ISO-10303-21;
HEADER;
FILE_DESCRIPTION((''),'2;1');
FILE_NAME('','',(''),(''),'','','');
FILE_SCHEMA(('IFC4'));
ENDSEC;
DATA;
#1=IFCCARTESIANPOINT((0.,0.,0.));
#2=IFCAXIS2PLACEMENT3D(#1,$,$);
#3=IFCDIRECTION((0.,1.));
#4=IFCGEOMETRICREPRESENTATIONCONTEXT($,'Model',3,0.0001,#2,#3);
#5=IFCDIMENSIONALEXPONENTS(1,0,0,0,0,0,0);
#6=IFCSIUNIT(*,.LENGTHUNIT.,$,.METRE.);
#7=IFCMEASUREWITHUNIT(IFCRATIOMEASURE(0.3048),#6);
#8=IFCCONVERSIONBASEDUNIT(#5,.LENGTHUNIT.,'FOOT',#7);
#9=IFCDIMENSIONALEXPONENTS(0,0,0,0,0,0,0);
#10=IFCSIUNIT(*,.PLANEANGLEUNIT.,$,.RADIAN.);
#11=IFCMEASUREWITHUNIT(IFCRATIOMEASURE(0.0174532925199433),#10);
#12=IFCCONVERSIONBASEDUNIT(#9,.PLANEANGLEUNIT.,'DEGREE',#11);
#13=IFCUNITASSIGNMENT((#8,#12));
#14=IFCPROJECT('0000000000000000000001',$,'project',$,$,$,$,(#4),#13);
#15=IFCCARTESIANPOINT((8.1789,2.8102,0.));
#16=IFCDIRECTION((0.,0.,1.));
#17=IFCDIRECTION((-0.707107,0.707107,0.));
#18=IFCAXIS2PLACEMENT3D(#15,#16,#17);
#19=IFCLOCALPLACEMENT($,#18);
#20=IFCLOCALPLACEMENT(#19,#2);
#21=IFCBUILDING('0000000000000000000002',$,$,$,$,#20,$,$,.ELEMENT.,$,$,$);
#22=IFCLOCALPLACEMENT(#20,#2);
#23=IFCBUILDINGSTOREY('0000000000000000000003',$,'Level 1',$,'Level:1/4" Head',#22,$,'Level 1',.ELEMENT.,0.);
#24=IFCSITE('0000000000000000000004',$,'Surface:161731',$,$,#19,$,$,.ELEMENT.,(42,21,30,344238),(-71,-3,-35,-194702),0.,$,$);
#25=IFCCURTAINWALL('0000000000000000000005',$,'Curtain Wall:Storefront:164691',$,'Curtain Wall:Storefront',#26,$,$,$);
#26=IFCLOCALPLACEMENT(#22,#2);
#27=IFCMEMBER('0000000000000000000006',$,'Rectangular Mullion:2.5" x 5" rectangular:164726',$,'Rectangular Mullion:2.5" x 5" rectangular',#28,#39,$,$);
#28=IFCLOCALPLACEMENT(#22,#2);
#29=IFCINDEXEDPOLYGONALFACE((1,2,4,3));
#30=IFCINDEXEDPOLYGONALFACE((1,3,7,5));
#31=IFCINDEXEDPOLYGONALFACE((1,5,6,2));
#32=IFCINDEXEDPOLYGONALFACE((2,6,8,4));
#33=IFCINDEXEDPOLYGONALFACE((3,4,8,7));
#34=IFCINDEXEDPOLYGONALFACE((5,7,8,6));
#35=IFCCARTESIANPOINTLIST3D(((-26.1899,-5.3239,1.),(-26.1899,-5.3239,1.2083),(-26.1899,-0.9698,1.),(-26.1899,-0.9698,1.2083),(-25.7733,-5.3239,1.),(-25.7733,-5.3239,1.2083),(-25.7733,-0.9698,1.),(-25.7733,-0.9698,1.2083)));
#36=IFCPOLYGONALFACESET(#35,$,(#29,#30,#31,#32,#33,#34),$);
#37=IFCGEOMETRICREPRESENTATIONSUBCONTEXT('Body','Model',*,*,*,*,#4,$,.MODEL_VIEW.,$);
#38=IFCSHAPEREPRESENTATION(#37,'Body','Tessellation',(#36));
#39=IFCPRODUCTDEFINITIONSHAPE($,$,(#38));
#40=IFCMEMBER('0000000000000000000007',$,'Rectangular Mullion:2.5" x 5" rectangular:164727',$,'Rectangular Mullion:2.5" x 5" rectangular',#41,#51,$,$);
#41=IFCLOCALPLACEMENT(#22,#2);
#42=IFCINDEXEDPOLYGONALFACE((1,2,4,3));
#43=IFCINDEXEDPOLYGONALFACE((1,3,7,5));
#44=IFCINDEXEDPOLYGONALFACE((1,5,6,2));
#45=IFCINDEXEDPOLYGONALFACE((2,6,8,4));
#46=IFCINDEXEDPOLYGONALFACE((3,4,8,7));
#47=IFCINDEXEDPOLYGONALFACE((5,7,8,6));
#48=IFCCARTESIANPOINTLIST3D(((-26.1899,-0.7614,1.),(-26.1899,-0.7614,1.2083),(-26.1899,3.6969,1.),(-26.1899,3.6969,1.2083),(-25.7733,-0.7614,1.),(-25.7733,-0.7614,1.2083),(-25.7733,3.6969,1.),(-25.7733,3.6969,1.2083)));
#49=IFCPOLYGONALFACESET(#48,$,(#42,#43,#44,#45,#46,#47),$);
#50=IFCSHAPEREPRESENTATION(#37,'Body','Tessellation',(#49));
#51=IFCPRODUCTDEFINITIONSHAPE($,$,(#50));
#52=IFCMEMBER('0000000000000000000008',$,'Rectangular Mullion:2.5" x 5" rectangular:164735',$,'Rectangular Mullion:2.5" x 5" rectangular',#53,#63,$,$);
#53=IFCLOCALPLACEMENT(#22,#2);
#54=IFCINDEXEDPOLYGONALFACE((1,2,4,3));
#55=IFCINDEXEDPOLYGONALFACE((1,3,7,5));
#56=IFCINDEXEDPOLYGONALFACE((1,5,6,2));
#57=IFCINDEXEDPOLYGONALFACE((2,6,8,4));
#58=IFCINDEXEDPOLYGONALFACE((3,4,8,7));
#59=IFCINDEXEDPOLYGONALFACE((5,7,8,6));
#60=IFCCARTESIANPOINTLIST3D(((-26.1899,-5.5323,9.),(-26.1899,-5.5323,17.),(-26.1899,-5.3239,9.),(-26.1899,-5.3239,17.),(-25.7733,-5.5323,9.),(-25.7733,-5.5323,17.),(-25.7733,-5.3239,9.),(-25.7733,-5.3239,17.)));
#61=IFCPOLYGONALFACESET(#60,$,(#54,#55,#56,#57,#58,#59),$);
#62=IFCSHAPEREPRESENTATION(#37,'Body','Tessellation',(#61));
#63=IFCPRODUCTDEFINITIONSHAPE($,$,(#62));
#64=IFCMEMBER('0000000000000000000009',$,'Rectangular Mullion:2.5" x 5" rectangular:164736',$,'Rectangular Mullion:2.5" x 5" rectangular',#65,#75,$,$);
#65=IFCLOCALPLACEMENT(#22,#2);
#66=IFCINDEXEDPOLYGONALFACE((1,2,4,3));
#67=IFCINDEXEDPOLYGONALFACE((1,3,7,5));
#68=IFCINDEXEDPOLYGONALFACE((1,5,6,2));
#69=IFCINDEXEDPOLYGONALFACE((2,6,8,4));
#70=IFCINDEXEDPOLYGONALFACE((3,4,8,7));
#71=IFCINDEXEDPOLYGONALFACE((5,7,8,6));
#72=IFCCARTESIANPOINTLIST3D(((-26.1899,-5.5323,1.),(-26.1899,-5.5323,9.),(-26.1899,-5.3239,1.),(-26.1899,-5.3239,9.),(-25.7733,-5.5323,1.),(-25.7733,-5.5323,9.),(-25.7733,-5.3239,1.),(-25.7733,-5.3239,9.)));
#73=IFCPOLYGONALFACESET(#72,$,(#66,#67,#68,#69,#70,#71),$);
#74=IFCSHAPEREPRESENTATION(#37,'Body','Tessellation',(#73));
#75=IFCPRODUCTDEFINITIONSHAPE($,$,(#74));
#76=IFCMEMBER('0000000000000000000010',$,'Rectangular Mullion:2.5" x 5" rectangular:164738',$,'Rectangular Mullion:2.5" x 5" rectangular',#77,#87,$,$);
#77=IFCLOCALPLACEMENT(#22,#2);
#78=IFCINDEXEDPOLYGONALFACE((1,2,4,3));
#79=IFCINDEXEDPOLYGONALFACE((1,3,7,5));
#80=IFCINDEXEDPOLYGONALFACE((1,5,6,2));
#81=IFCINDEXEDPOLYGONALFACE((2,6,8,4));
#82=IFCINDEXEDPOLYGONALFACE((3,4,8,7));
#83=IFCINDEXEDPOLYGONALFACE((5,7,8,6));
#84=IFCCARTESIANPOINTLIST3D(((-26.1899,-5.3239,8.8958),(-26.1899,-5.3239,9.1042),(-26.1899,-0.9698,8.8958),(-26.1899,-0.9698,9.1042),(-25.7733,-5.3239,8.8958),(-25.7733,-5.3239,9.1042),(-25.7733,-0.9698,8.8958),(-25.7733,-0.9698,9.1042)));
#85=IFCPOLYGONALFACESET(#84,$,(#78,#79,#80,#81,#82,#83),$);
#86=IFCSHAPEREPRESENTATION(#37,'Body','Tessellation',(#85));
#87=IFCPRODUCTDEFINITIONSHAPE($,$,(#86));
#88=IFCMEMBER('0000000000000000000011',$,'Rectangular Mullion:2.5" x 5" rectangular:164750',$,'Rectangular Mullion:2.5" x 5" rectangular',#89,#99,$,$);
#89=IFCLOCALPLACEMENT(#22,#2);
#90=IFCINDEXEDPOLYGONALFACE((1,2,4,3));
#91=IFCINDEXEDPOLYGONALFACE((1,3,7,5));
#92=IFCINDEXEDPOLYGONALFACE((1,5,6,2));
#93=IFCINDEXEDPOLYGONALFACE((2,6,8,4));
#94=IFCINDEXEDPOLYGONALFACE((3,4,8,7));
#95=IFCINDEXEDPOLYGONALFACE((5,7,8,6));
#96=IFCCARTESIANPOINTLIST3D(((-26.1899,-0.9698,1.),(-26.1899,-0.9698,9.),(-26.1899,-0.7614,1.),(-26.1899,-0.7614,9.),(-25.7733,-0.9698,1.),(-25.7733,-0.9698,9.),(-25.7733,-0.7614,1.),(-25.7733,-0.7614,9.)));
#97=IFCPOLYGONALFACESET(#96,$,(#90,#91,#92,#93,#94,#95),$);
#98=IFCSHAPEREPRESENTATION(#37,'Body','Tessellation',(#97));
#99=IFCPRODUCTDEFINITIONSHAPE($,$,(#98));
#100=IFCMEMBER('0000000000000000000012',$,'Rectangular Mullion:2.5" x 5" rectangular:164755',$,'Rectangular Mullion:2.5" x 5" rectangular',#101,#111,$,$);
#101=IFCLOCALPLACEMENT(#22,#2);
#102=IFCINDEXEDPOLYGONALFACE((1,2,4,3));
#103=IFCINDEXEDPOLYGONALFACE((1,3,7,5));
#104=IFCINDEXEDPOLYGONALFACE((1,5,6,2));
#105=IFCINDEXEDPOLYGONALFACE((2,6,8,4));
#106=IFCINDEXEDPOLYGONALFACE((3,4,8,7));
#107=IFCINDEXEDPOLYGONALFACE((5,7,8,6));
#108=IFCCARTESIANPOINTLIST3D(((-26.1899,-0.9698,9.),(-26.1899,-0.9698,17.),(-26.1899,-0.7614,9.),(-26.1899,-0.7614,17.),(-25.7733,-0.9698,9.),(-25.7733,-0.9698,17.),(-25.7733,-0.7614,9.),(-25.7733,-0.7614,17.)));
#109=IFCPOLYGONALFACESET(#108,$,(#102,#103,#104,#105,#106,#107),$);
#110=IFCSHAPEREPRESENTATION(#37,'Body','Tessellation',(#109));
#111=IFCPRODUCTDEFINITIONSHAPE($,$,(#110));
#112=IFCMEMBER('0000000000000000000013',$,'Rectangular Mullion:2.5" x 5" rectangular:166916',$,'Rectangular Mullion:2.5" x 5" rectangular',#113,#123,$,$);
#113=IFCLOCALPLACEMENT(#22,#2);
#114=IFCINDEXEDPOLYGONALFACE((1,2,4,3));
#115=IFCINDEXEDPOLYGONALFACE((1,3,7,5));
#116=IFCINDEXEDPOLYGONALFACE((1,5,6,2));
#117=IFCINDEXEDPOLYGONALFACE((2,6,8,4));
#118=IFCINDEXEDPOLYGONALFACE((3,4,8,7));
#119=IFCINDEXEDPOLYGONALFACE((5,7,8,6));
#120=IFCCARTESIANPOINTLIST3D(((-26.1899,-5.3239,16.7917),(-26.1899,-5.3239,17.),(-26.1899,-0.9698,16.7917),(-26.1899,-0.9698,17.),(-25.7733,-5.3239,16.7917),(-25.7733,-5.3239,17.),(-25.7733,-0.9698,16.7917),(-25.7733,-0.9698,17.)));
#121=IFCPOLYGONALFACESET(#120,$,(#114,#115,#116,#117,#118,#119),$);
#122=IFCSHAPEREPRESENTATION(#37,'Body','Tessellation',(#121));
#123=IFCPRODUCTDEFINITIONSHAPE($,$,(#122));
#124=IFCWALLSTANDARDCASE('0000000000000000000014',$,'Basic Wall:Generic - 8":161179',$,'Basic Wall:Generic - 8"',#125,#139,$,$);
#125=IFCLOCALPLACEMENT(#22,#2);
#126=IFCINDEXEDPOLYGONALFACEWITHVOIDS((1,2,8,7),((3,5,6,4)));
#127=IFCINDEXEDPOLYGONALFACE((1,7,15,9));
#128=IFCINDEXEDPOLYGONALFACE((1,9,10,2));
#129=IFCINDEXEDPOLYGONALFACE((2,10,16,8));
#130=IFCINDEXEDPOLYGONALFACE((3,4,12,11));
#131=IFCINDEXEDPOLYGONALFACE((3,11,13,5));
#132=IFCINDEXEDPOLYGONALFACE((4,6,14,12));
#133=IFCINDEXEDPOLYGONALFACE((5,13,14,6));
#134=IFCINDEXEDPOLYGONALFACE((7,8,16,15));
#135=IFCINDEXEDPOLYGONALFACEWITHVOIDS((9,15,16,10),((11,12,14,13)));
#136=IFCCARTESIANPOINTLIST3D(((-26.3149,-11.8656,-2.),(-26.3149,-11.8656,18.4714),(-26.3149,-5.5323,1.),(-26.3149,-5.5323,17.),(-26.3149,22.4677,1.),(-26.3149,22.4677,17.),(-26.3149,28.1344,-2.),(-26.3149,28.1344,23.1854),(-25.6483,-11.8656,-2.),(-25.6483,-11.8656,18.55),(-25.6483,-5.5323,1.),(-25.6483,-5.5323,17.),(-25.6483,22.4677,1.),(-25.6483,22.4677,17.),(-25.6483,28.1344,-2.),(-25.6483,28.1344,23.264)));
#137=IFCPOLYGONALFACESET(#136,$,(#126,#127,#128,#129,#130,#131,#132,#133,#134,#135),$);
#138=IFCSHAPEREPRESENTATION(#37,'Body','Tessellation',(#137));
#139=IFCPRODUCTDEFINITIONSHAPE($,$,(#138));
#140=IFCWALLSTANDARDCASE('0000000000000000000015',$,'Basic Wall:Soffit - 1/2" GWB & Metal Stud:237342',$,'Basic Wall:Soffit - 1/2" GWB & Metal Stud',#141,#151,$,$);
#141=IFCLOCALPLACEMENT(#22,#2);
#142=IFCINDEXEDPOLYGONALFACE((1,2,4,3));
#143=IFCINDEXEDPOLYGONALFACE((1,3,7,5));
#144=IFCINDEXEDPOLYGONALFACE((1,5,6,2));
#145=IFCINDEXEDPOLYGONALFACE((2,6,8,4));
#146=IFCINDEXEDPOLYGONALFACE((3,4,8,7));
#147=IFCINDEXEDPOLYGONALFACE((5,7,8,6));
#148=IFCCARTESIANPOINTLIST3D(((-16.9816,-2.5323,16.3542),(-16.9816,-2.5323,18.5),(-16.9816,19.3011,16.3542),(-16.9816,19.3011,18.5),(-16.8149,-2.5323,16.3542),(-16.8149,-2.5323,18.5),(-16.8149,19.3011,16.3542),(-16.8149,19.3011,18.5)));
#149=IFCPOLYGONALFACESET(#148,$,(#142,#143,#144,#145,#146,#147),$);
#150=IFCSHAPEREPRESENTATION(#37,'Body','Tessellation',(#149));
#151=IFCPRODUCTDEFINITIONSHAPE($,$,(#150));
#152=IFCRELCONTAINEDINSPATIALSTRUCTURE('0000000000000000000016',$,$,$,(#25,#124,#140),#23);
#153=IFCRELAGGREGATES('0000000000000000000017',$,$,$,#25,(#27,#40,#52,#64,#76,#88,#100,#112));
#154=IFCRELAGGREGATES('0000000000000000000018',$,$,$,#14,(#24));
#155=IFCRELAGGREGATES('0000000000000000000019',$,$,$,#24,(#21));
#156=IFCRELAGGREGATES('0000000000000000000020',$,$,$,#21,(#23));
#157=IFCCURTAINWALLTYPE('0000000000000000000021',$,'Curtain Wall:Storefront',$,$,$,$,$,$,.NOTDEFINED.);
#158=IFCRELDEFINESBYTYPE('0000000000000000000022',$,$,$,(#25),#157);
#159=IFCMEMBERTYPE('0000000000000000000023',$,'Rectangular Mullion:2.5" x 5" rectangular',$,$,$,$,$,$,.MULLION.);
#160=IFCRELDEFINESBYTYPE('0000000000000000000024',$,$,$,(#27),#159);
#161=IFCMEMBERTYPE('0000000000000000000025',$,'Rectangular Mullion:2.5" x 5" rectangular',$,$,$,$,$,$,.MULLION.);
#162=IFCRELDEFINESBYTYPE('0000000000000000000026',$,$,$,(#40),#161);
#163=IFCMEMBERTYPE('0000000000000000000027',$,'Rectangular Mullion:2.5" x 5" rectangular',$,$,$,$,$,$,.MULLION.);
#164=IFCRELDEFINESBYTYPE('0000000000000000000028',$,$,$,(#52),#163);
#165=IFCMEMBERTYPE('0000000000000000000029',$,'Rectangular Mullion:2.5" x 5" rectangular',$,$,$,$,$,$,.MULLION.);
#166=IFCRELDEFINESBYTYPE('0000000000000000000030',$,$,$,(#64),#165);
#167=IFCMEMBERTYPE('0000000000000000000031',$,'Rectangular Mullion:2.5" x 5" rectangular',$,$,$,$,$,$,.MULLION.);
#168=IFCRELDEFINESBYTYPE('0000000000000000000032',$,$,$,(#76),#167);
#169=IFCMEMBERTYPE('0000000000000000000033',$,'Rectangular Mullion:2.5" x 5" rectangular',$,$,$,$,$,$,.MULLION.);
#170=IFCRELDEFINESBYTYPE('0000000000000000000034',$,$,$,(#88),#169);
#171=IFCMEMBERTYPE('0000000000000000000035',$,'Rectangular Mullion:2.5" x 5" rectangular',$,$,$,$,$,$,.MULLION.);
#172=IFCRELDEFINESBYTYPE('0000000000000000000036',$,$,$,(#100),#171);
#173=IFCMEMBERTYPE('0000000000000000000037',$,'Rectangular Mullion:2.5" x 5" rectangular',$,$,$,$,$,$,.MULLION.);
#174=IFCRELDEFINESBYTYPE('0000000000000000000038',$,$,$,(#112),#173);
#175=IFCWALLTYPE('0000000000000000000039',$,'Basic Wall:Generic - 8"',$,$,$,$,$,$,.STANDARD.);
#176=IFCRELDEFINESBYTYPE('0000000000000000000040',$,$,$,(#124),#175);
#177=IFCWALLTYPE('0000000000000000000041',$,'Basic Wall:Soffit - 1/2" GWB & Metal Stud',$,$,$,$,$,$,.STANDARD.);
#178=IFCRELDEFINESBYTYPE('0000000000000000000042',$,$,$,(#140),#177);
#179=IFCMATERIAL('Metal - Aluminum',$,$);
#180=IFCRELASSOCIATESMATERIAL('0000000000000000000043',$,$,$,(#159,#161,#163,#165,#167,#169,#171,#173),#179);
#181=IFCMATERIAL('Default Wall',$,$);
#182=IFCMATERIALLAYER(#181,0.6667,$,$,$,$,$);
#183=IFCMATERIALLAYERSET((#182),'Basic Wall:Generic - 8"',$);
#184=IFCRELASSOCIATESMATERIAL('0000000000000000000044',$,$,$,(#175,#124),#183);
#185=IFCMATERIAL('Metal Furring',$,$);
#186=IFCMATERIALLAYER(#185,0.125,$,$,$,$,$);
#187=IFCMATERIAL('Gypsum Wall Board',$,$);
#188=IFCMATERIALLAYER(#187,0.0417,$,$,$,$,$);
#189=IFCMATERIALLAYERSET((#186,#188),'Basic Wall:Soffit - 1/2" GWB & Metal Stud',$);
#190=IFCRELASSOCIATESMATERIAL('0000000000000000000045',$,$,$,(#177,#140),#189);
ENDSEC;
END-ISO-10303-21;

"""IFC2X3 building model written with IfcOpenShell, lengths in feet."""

from ifc_helpers import new_model, entity, si_unit, converted_unit, direction, frame, frame_2d, origin, origin_2d_with_axis, place, context, subcontext, project, spatial, polyline, rectangle, extrude, clip, bounded_halfspace, source, transform, mapped, material, layer, layer_set, layer_usage, type_object, type_shapes, element, aggregate, save


model = new_model("IFC2X3")

# Units and contexts
model_context = context("Model", 3, precision=0.0001, world=origin(), true_north=direction((0.0, 1.0)))
body_context = subcontext(model_context, "Body", "Model", "MODEL_VIEW")
ifc_project = project(units=[converted_unit("LENGTHUNIT", "FOOT", entity("IfcRatioMeasure", 0.3048), si_unit("LENGTHUNIT", "METRE"), dimensions=[1, 0, 0, 0, 0, 0, 0]), converted_unit("PLANEANGLEUNIT", "DEGREE", entity("IfcRatioMeasure", 0.0174532925199433), si_unit("PLANEANGLEUNIT", "RADIAN"), dimensions=[0, 0, 0, 0, 0, 0, 0])], contexts=[model_context])

# Site, building, storey
site_placement = place(None, frame((8.1789, 2.8102, 0.0), z_axis=(0.0, 0.0, 1.0), x_axis=(-0.707107, 0.707107, 0.0)))
site = spatial("IfcSite", under=ifc_project, at=site_placement, Name="Surface:161731", CompositionType="ELEMENT", RefLatitude=(42, 21, 30, 344238), RefLongitude=(-71, -3, -35, -194702), RefElevation=0.0)
building_placement = place(site_placement, origin())
building = spatial("IfcBuilding", under=site, at=building_placement, CompositionType="ELEMENT")
storey_placement = place(building_placement, origin())
storey = spatial("IfcBuildingStorey", under=building, at=storey_placement, Name="Level 1", ObjectType="Level:1/4\" Head", LongName="Level 1", CompositionType="ELEMENT", Elevation=0.0)

# Curtain wall, members
curtain_wall_type = type_object("IfcCurtainWallType", Name="Curtain Wall:Storefront", PredefinedType="NOTDEFINED")
curtain_wall_placement = place(storey_placement, origin())
curtain_wall = element("IfcCurtainWall", 1, at=curtain_wall_placement, inside=storey, type_object=curtain_wall_type, Name="Curtain Wall:Storefront:164691", ObjectType="Curtain Wall:Storefront")
ifc_material_1 = material(Name="Metal - Aluminum")
member_type_1 = type_object("IfcMemberType", Name="Rectangular Mullion:2.5\" x 5\" rectangular", PredefinedType="MULLION", material=ifc_material_1)
shared_shape_1 = source(origin(), body_context, "Body", "SweptSolid", [
    extrude(rectangle(XDim=0.4167, YDim=0.2083, at=origin_2d_with_axis()), frame((-0.1042, 0.0, -4.3542), z_axis=(0.0, 0.0, 1.0), x_axis=(0.0, -1.0, 0.0)), (0.0, 0.0, 1.0), 4.3542),
])
type_shapes(member_type_1, [shared_shape_1])
member_1_placement = place(curtain_wall_placement, frame((-25.9816, -5.3239, 1.0), z_axis=(0.0, -1.0, 0.0), x_axis=(0.0, 0.0, -1.0)))
member_1 = element("IfcMember", 2, at=member_1_placement, type_object=member_type_1, Name="Rectangular Mullion:2.5\" x 5\" rectangular:164726", ObjectType="Rectangular Mullion:2.5\" x 5\" rectangular", context=body_context, shape_type="MappedRepresentation", body=[
    mapped(shared_shape_1, transform((0.0, 0.0, 0.0), scale=1.0)),
])
member_type_2 = type_object("IfcMemberType", Name="Rectangular Mullion:2.5\" x 5\" rectangular", PredefinedType="MULLION", material=ifc_material_1)
shared_shape_2 = source(origin(), body_context, "Body", "SweptSolid", [
    extrude(rectangle(XDim=0.4167, YDim=0.2083, at=origin_2d_with_axis()), frame((-0.1042, 0.0, -4.4583), z_axis=(0.0, 0.0, 1.0), x_axis=(0.0, -1.0, 0.0)), (0.0, 0.0, 1.0), 4.4583),
])
type_shapes(member_type_2, [shared_shape_2])
member_2_placement = place(curtain_wall_placement, frame((-25.9816, -0.7614, 1.0), z_axis=(0.0, -1.0, 0.0), x_axis=(0.0, 0.0, -1.0)))
member_2 = element("IfcMember", 3, at=member_2_placement, type_object=member_type_2, Name="Rectangular Mullion:2.5\" x 5\" rectangular:164727", ObjectType="Rectangular Mullion:2.5\" x 5\" rectangular", context=body_context, shape_type="MappedRepresentation", body=[
    mapped(shared_shape_2, transform((0.0, 0.0, 0.0), scale=1.0)),
])
member_type_3 = type_object("IfcMemberType", Name="Rectangular Mullion:2.5\" x 5\" rectangular", PredefinedType="MULLION", material=ifc_material_1)
shared_shape_3 = source(origin(), body_context, "Body", "SweptSolid", [
    extrude(rectangle(XDim=0.4167, YDim=0.2083, at=origin_2d_with_axis()), frame((-0.1042, 0.0, -8.0), z_axis=(0.0, 0.0, 1.0), x_axis=(0.0, -1.0, 0.0)), (0.0, 0.0, 1.0), 8.0),
])
type_shapes(member_type_3, [shared_shape_3])
member_3_placement = place(curtain_wall_placement, frame((-25.9816, -5.5323, 17.0), z_axis=(0.0, 0.0, 1.0), x_axis=(0.0, -1.0, 0.0)))
member_3 = element("IfcMember", 4, at=member_3_placement, type_object=member_type_3, Name="Rectangular Mullion:2.5\" x 5\" rectangular:164735", ObjectType="Rectangular Mullion:2.5\" x 5\" rectangular", context=body_context, shape_type="MappedRepresentation", body=[
    mapped(shared_shape_3, transform((0.0, 0.0, 0.0), scale=1.0)),
])
member_type_4 = type_object("IfcMemberType", Name="Rectangular Mullion:2.5\" x 5\" rectangular", PredefinedType="MULLION", material=ifc_material_1)
shared_shape_4 = source(origin(), body_context, "Body", "SweptSolid", [
    extrude(rectangle(XDim=0.4167, YDim=0.2083, at=origin_2d_with_axis()), frame((-0.1042, 0.0, -8.0), z_axis=(0.0, 0.0, 1.0), x_axis=(0.0, -1.0, 0.0)), (0.0, 0.0, 1.0), 8.0),
])
type_shapes(member_type_4, [shared_shape_4])
member_4_placement = place(curtain_wall_placement, frame((-25.9816, -5.5323, 9.0), z_axis=(0.0, 0.0, 1.0), x_axis=(0.0, -1.0, 0.0)))
member_4 = element("IfcMember", 5, at=member_4_placement, type_object=member_type_4, Name="Rectangular Mullion:2.5\" x 5\" rectangular:164736", ObjectType="Rectangular Mullion:2.5\" x 5\" rectangular", context=body_context, shape_type="MappedRepresentation", body=[
    mapped(shared_shape_4, transform((0.0, 0.0, 0.0), scale=1.0)),
])
member_type_5 = type_object("IfcMemberType", Name="Rectangular Mullion:2.5\" x 5\" rectangular", PredefinedType="MULLION", material=ifc_material_1)
shared_shape_5 = source(origin(), body_context, "Body", "SweptSolid", [
    extrude(rectangle(XDim=0.4167, YDim=0.2083, at=origin_2d_with_axis()), frame((0.0, 0.0, -4.3542), z_axis=(0.0, 0.0, 1.0), x_axis=(0.0, -1.0, 0.0)), (0.0, 0.0, 1.0), 4.3542),
])
type_shapes(member_type_5, [shared_shape_5])
member_5_placement = place(curtain_wall_placement, frame((-25.9816, -0.9698, 9.0), z_axis=(0.0, 1.0, 0.0), x_axis=(0.0, 0.0, 1.0)))
member_5 = element("IfcMember", 6, at=member_5_placement, type_object=member_type_5, Name="Rectangular Mullion:2.5\" x 5\" rectangular:164738", ObjectType="Rectangular Mullion:2.5\" x 5\" rectangular", context=body_context, shape_type="MappedRepresentation", body=[
    mapped(shared_shape_5, transform((0.0, 0.0, 0.0), scale=1.0)),
])
member_type_6 = type_object("IfcMemberType", Name="Rectangular Mullion:2.5\" x 5\" rectangular", PredefinedType="MULLION", material=ifc_material_1)
shared_shape_6 = source(origin(), body_context, "Body", "SweptSolid", [
    extrude(rectangle(XDim=0.4167, YDim=0.2083, at=origin_2d_with_axis()), frame((0.0, 0.0, -8.0), z_axis=(0.0, 0.0, 1.0), x_axis=(0.0, -1.0, 0.0)), (0.0, 0.0, 1.0), 8.0),
])
type_shapes(member_type_6, [shared_shape_6])
member_6_placement = place(curtain_wall_placement, frame((-25.9816, -0.8656, 1.0), z_axis=(0.0, 0.0, -1.0), x_axis=(0.0, 1.0, 0.0)))
member_6 = element("IfcMember", 7, at=member_6_placement, type_object=member_type_6, Name="Rectangular Mullion:2.5\" x 5\" rectangular:164750", ObjectType="Rectangular Mullion:2.5\" x 5\" rectangular", context=body_context, shape_type="MappedRepresentation", body=[
    mapped(shared_shape_6, transform((0.0, 0.0, 0.0), scale=1.0)),
])
member_type_7 = type_object("IfcMemberType", Name="Rectangular Mullion:2.5\" x 5\" rectangular", PredefinedType="MULLION", material=ifc_material_1)
shared_shape_7 = source(origin(), body_context, "Body", "SweptSolid", [
    extrude(rectangle(XDim=0.4167, YDim=0.2083, at=origin_2d_with_axis()), frame((0.0, 0.0, -8.0), z_axis=(0.0, 0.0, 1.0), x_axis=(0.0, -1.0, 0.0)), (0.0, 0.0, 1.0), 8.0),
])
type_shapes(member_type_7, [shared_shape_7])
member_7_placement = place(curtain_wall_placement, frame((-25.9816, -0.8656, 9.0), z_axis=(0.0, 0.0, -1.0), x_axis=(0.0, 1.0, 0.0)))
member_7 = element("IfcMember", 8, at=member_7_placement, type_object=member_type_7, Name="Rectangular Mullion:2.5\" x 5\" rectangular:164755", ObjectType="Rectangular Mullion:2.5\" x 5\" rectangular", context=body_context, shape_type="MappedRepresentation", body=[
    mapped(shared_shape_7, transform((0.0, 0.0, 0.0), scale=1.0)),
])
member_type_8 = type_object("IfcMemberType", Name="Rectangular Mullion:2.5\" x 5\" rectangular", PredefinedType="MULLION", material=ifc_material_1)
shared_shape_8 = source(origin(), body_context, "Body", "SweptSolid", [
    extrude(rectangle(XDim=0.4167, YDim=0.2083, at=origin_2d_with_axis()), frame((-0.1042, 0.0, -4.3542), z_axis=(0.0, 0.0, 1.0), x_axis=(0.0, -1.0, 0.0)), (0.0, 0.0, 1.0), 4.3542),
])
type_shapes(member_type_8, [shared_shape_8])
member_8_placement = place(curtain_wall_placement, frame((-25.9816, -0.9698, 17.0), z_axis=(0.0, 1.0, 0.0), x_axis=(0.0, 0.0, 1.0)))
member_8 = element("IfcMember", 9, at=member_8_placement, type_object=member_type_8, Name="Rectangular Mullion:2.5\" x 5\" rectangular:166916", ObjectType="Rectangular Mullion:2.5\" x 5\" rectangular", context=body_context, shape_type="MappedRepresentation", body=[
    mapped(shared_shape_8, transform((0.0, 0.0, 0.0), scale=1.0)),
])
aggregate(curtain_wall, [member_1, member_2, member_3, member_4, member_5, member_6, member_7, member_8])

# Wall, opening
ifc_material_2 = material(Name="Default Wall")
ifc_layer_1 = layer(ifc_material_2, 0.6667)
ifc_layer_set_1 = layer_set([ifc_layer_1], Name="Basic Wall:Generic - 8\"")
ifc_layer_usage_1 = layer_usage(ifc_layer_set_1, "AXIS2", "NEGATIVE", 0.3333)
wall_type_1 = type_object("IfcWallType", Name="Basic Wall:Generic - 8\"", PredefinedType="STANDARD", material=ifc_layer_set_1)
wall_1_placement = place(storey_placement, frame((-25.9816, -11.8656, -2.0), z_axis=(0.0, 0.0, 1.0), x_axis=(0.0, 1.0, 0.0)))
wall_1 = element("IfcWallStandardCase", 10, at=wall_1_placement, inside=storey, type_object=wall_type_1, material=ifc_layer_usage_1, Name="Basic Wall:Generic - 8\":161179", ObjectType="Basic Wall:Generic - 8\"", context=body_context, shape_type="Clipping", body=[
    clip(extrude(rectangle(XDim=40.0, YDim=0.6667, at=frame_2d((20.0, 0.0), x_axis=(-1.0, 0.0))), origin(), (0.0, 0.0, 1.0), 25.264), bounded_halfspace(frame((0.0, -0.3333, 20.55), z_axis=(-0.116248, 0.116248, 0.986394), x_axis=(-0.707107, -0.707107, 0.0)), False, frame((0.0, -0.3333, 20.55)), polyline([(0.0, 0.0), (0.6667, 0.0), (40.0, 0.0), (40.0, 0.6667), (0.0, 0.6667), (0.0, 0.0)]))),
])
opening_placement = place(wall_1_placement, origin())
element("IfcOpeningElement", 11, at=opening_placement, cuts=wall_1, ObjectType="Opening", context=body_context, shape_type="SweptSolid", body=[
    extrude(rectangle(XDim=16.0, YDim=28.0, at=origin_2d_with_axis()), frame((20.3333, -0.8333, 11.0), z_axis=(0.0, 1.0, 0.0), x_axis=(0.0, 0.0, 1.0)), (0.0, 0.0, 1.0), 1.6667),
])

# Wall
ifc_material_3 = material(Name="Metal Furring")
ifc_layer_2 = layer(ifc_material_3, 0.125)
ifc_material_4 = material(Name="Gypsum Wall Board")
ifc_layer_3 = layer(ifc_material_4, 0.0417)
ifc_layer_set_2 = layer_set([ifc_layer_2, ifc_layer_3], Name="Basic Wall:Soffit - 1/2\" GWB & Metal Stud")
ifc_layer_usage_2 = layer_usage(ifc_layer_set_2, "AXIS2", "POSITIVE", -0.0833)
wall_type_2 = type_object("IfcWallType", Name="Basic Wall:Soffit - 1/2\" GWB & Metal Stud", PredefinedType="STANDARD", material=ifc_layer_set_2)
wall_2_placement = place(storey_placement, frame((-16.8983, -2.5323, 16.3542), z_axis=(0.0, 0.0, 1.0), x_axis=(0.0, 1.0, 0.0)))
element("IfcWallStandardCase", 12, at=wall_2_placement, inside=storey, type_object=wall_type_2, material=ifc_layer_usage_2, Name="Basic Wall:Soffit - 1/2\" GWB & Metal Stud:237342", ObjectType="Basic Wall:Soffit - 1/2\" GWB & Metal Stud", context=body_context, shape_type="Clipping", body=[
    clip(extrude(rectangle(XDim=21.8333, YDim=0.1667, at=frame_2d((10.9167, 0.0), x_axis=(-1.0, 0.0))), origin(), (0.0, 0.0, 1.0), 2.1458), bounded_halfspace(frame((21.8333, -0.0833, 0.0), z_axis=(0.0, 0.0, 1.0), x_axis=(-1.0, 0.0, 0.0)), True, frame((21.8333, -0.0833, 0.0)), polyline([(0.0, 0.0), (0.0, 0.1667), (-21.8333, 0.1667), (-21.8333, 0.0), (-21.6667, 0.0), (0.0, 0.0)]))),
])

save(model, "model.ifc")
